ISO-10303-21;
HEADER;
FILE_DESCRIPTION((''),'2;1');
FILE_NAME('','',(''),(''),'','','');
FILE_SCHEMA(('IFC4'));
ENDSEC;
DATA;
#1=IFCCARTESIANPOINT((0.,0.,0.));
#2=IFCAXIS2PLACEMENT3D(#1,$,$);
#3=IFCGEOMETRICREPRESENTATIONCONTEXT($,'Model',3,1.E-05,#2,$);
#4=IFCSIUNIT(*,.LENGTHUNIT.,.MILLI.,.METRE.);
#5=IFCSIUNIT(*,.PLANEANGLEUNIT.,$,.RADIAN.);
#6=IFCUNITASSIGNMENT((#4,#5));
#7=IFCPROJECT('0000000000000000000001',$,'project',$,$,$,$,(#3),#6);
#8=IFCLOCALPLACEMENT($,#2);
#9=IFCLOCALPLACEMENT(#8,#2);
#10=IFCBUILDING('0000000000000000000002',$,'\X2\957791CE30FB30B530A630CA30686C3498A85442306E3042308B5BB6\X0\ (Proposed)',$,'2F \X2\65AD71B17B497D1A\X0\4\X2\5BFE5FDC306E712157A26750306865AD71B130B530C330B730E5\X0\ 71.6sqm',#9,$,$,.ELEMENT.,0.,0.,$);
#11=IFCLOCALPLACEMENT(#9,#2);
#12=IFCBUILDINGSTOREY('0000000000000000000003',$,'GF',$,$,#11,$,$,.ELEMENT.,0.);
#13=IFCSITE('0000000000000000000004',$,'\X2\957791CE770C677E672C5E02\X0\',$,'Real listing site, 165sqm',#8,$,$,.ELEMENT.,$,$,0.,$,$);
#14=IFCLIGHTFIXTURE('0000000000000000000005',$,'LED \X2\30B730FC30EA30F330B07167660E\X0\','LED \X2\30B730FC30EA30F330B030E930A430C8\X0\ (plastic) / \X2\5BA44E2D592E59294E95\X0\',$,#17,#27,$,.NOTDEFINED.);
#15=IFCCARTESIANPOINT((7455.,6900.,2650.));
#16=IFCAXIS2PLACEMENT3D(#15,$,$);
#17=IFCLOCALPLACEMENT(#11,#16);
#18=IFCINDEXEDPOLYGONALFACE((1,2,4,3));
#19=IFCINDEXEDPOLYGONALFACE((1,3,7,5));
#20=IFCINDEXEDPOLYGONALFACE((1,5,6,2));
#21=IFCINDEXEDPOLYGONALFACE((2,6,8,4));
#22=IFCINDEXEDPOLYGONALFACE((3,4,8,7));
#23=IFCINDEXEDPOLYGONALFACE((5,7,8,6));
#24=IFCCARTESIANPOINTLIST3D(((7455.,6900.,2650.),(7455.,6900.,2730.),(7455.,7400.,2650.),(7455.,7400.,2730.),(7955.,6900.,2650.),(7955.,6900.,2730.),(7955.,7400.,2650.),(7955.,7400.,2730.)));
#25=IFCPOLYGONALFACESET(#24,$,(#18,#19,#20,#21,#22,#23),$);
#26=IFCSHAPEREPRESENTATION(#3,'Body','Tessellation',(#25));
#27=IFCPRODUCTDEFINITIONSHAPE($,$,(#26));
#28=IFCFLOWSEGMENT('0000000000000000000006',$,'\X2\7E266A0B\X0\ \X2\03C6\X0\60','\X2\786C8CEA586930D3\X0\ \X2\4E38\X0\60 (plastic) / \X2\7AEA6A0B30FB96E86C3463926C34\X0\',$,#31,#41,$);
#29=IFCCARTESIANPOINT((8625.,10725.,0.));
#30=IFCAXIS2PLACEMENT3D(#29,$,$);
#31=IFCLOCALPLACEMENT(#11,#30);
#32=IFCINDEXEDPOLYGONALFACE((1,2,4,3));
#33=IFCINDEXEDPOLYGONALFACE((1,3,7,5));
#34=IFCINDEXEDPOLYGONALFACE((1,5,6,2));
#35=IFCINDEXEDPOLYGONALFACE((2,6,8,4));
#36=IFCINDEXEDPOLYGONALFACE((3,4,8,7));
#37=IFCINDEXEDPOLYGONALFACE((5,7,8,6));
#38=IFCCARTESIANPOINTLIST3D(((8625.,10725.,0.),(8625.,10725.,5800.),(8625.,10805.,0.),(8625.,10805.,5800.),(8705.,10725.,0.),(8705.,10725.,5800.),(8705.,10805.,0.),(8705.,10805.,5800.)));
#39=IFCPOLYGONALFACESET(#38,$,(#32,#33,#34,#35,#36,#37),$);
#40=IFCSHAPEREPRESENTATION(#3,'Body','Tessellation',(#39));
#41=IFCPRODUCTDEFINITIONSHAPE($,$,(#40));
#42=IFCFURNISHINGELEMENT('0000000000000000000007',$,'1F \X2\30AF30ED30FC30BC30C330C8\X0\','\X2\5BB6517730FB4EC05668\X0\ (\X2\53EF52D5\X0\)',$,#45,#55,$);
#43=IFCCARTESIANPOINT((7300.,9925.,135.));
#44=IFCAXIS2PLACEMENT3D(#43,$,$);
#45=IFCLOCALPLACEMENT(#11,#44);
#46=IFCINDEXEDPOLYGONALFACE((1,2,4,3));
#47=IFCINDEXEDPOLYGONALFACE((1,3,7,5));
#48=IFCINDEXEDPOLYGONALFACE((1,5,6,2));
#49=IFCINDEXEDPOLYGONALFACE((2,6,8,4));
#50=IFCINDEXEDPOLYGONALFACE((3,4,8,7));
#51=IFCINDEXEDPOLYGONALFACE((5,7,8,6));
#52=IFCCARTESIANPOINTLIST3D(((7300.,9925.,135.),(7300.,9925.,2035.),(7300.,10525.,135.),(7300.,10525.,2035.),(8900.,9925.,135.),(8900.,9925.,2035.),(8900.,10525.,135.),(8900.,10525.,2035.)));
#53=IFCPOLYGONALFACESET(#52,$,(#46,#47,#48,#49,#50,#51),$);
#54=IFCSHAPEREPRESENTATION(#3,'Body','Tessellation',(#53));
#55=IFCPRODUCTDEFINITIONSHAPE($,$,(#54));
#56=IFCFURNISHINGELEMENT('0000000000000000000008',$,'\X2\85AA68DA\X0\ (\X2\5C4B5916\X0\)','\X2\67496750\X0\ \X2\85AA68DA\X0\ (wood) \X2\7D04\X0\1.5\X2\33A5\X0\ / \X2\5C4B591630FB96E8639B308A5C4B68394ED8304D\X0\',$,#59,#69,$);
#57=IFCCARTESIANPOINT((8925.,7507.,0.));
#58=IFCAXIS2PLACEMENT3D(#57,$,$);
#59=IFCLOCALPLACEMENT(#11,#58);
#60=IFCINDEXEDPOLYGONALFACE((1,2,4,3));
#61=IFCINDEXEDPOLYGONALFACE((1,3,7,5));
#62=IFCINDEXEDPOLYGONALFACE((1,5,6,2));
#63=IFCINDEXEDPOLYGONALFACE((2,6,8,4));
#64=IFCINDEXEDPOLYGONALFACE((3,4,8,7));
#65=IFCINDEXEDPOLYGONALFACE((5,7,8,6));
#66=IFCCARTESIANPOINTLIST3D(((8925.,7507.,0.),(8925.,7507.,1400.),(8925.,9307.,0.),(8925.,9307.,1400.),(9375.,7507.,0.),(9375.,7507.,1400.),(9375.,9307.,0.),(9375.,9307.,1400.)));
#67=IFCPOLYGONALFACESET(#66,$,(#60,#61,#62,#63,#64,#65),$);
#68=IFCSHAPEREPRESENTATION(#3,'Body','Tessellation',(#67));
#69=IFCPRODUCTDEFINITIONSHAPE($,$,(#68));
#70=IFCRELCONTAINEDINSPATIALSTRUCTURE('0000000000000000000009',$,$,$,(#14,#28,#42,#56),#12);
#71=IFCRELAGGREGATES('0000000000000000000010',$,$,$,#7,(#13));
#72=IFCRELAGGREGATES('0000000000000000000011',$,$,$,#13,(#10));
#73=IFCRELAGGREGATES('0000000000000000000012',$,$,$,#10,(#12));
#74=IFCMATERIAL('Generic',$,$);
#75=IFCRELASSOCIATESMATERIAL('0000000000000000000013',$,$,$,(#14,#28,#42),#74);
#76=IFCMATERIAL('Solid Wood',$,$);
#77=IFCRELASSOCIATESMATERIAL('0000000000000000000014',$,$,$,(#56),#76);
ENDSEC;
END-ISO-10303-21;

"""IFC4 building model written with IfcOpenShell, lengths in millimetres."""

from ifc_helpers import new_model, si_unit, frame, frame_2d, origin, place, context, project, spatial, rectangle, extrude, material, element, save


model = new_model("IFC4")

# Units and contexts
model_context = context("Model", 3, precision=1e-05, world=origin())
ifc_project = project(units=[si_unit("LENGTHUNIT", "METRE", prefix="MILLI"), si_unit("PLANEANGLEUNIT", "RADIAN")], contexts=[model_context])

# Site, building, storey
site_placement = place(None, origin())
site = spatial("IfcSite", under=ifc_project, at=site_placement, Name="長野県松本市", ObjectType="Real listing site, 165sqm", CompositionType="ELEMENT", RefElevation=0.0)
building_placement = place(site_placement, origin())
building = spatial("IfcBuilding", under=site, at=building_placement, Name="長野・サウナと水風呂のある家 (Proposed)", ObjectType="2F 断熱等級4対応の無垢材と断熱サッシュ 71.6sqm", CompositionType="ELEMENT", ElevationOfRefHeight=0.0, ElevationOfTerrain=0.0)
storey_placement = place(building_placement, origin())
storey = spatial("IfcBuildingStorey", under=building, at=storey_placement, Name="GF", CompositionType="ELEMENT", Elevation=0.0)

# Shared definitions
ifc_material_1 = material(Name="Solid Wood")

# Shared definitions
ifc_material_2 = material(Name="Generic")

# Light fixture
light_fixture_placement = place(storey_placement, frame((7455.0, 6900.0, 2650.0)))
element("IfcLightFixture", 1, at=light_fixture_placement, inside=storey, material=ifc_material_2, Name="LED シーリング照明", Description="LED シーリングライト (plastic) / 室中央天井", PredefinedType="NOTDEFINED", context=model_context, shape_type="SweptSolid", body=[
    extrude(rectangle(XDim=500.0, YDim=500.0, at=frame_2d((250.0, 250.0))), frame((7455.0, 6900.0, 2650.0)), (0.0, 0.0, 1.0), 80.0),
])

# Flow segment
flow_segment_placement = place(storey_placement, frame((8625.0, 10725.0, 0.0)))
element("IfcFlowSegment", 2, at=flow_segment_placement, inside=storey, material=ifc_material_2, Name="縦樋 φ60", Description="硬質塩ビ 丸60 (plastic) / 竪樋・雨水排水", context=model_context, shape_type="SweptSolid", body=[
    extrude(rectangle(XDim=80.0, YDim=80.0, at=frame_2d((40.0, 40.0))), frame((8625.0, 10725.0, 0.0)), (0.0, 0.0, 1.0), 5800.0),
])

# Furnishing elements
furnishing_1_placement = place(storey_placement, frame((7300.0, 9925.0, 135.0)))
element("IfcFurnishingElement", 3, at=furnishing_1_placement, inside=storey, material=ifc_material_2, Name="1F クローゼット", Description="家具・什器 (可動)", context=model_context, shape_type="SweptSolid", body=[
    extrude(rectangle(XDim=1600.0, YDim=600.0, at=frame_2d((800.0, 300.0))), frame((7300.0, 9925.0, 135.0)), (0.0, 0.0, 1.0), 1900.0),
])
furnishing_2_placement = place(storey_placement, frame((8925.0, 7507.0, 0.0)))
element("IfcFurnishingElement", 4, at=furnishing_2_placement, inside=storey, material=ifc_material_1, Name="薪棚 (屋外)", Description="杉材 薪棚 (wood) 約1.5㎥ / 屋外・雨掛り屋根付き", context=model_context, shape_type="SweptSolid", body=[
    extrude(rectangle(XDim=450.0, YDim=1800.0, at=frame_2d((225.0, 900.0))), frame((8925.0, 7507.0, 0.0)), (0.0, 0.0, 1.0), 1400.0),
])

save(model, "model.ifc")
